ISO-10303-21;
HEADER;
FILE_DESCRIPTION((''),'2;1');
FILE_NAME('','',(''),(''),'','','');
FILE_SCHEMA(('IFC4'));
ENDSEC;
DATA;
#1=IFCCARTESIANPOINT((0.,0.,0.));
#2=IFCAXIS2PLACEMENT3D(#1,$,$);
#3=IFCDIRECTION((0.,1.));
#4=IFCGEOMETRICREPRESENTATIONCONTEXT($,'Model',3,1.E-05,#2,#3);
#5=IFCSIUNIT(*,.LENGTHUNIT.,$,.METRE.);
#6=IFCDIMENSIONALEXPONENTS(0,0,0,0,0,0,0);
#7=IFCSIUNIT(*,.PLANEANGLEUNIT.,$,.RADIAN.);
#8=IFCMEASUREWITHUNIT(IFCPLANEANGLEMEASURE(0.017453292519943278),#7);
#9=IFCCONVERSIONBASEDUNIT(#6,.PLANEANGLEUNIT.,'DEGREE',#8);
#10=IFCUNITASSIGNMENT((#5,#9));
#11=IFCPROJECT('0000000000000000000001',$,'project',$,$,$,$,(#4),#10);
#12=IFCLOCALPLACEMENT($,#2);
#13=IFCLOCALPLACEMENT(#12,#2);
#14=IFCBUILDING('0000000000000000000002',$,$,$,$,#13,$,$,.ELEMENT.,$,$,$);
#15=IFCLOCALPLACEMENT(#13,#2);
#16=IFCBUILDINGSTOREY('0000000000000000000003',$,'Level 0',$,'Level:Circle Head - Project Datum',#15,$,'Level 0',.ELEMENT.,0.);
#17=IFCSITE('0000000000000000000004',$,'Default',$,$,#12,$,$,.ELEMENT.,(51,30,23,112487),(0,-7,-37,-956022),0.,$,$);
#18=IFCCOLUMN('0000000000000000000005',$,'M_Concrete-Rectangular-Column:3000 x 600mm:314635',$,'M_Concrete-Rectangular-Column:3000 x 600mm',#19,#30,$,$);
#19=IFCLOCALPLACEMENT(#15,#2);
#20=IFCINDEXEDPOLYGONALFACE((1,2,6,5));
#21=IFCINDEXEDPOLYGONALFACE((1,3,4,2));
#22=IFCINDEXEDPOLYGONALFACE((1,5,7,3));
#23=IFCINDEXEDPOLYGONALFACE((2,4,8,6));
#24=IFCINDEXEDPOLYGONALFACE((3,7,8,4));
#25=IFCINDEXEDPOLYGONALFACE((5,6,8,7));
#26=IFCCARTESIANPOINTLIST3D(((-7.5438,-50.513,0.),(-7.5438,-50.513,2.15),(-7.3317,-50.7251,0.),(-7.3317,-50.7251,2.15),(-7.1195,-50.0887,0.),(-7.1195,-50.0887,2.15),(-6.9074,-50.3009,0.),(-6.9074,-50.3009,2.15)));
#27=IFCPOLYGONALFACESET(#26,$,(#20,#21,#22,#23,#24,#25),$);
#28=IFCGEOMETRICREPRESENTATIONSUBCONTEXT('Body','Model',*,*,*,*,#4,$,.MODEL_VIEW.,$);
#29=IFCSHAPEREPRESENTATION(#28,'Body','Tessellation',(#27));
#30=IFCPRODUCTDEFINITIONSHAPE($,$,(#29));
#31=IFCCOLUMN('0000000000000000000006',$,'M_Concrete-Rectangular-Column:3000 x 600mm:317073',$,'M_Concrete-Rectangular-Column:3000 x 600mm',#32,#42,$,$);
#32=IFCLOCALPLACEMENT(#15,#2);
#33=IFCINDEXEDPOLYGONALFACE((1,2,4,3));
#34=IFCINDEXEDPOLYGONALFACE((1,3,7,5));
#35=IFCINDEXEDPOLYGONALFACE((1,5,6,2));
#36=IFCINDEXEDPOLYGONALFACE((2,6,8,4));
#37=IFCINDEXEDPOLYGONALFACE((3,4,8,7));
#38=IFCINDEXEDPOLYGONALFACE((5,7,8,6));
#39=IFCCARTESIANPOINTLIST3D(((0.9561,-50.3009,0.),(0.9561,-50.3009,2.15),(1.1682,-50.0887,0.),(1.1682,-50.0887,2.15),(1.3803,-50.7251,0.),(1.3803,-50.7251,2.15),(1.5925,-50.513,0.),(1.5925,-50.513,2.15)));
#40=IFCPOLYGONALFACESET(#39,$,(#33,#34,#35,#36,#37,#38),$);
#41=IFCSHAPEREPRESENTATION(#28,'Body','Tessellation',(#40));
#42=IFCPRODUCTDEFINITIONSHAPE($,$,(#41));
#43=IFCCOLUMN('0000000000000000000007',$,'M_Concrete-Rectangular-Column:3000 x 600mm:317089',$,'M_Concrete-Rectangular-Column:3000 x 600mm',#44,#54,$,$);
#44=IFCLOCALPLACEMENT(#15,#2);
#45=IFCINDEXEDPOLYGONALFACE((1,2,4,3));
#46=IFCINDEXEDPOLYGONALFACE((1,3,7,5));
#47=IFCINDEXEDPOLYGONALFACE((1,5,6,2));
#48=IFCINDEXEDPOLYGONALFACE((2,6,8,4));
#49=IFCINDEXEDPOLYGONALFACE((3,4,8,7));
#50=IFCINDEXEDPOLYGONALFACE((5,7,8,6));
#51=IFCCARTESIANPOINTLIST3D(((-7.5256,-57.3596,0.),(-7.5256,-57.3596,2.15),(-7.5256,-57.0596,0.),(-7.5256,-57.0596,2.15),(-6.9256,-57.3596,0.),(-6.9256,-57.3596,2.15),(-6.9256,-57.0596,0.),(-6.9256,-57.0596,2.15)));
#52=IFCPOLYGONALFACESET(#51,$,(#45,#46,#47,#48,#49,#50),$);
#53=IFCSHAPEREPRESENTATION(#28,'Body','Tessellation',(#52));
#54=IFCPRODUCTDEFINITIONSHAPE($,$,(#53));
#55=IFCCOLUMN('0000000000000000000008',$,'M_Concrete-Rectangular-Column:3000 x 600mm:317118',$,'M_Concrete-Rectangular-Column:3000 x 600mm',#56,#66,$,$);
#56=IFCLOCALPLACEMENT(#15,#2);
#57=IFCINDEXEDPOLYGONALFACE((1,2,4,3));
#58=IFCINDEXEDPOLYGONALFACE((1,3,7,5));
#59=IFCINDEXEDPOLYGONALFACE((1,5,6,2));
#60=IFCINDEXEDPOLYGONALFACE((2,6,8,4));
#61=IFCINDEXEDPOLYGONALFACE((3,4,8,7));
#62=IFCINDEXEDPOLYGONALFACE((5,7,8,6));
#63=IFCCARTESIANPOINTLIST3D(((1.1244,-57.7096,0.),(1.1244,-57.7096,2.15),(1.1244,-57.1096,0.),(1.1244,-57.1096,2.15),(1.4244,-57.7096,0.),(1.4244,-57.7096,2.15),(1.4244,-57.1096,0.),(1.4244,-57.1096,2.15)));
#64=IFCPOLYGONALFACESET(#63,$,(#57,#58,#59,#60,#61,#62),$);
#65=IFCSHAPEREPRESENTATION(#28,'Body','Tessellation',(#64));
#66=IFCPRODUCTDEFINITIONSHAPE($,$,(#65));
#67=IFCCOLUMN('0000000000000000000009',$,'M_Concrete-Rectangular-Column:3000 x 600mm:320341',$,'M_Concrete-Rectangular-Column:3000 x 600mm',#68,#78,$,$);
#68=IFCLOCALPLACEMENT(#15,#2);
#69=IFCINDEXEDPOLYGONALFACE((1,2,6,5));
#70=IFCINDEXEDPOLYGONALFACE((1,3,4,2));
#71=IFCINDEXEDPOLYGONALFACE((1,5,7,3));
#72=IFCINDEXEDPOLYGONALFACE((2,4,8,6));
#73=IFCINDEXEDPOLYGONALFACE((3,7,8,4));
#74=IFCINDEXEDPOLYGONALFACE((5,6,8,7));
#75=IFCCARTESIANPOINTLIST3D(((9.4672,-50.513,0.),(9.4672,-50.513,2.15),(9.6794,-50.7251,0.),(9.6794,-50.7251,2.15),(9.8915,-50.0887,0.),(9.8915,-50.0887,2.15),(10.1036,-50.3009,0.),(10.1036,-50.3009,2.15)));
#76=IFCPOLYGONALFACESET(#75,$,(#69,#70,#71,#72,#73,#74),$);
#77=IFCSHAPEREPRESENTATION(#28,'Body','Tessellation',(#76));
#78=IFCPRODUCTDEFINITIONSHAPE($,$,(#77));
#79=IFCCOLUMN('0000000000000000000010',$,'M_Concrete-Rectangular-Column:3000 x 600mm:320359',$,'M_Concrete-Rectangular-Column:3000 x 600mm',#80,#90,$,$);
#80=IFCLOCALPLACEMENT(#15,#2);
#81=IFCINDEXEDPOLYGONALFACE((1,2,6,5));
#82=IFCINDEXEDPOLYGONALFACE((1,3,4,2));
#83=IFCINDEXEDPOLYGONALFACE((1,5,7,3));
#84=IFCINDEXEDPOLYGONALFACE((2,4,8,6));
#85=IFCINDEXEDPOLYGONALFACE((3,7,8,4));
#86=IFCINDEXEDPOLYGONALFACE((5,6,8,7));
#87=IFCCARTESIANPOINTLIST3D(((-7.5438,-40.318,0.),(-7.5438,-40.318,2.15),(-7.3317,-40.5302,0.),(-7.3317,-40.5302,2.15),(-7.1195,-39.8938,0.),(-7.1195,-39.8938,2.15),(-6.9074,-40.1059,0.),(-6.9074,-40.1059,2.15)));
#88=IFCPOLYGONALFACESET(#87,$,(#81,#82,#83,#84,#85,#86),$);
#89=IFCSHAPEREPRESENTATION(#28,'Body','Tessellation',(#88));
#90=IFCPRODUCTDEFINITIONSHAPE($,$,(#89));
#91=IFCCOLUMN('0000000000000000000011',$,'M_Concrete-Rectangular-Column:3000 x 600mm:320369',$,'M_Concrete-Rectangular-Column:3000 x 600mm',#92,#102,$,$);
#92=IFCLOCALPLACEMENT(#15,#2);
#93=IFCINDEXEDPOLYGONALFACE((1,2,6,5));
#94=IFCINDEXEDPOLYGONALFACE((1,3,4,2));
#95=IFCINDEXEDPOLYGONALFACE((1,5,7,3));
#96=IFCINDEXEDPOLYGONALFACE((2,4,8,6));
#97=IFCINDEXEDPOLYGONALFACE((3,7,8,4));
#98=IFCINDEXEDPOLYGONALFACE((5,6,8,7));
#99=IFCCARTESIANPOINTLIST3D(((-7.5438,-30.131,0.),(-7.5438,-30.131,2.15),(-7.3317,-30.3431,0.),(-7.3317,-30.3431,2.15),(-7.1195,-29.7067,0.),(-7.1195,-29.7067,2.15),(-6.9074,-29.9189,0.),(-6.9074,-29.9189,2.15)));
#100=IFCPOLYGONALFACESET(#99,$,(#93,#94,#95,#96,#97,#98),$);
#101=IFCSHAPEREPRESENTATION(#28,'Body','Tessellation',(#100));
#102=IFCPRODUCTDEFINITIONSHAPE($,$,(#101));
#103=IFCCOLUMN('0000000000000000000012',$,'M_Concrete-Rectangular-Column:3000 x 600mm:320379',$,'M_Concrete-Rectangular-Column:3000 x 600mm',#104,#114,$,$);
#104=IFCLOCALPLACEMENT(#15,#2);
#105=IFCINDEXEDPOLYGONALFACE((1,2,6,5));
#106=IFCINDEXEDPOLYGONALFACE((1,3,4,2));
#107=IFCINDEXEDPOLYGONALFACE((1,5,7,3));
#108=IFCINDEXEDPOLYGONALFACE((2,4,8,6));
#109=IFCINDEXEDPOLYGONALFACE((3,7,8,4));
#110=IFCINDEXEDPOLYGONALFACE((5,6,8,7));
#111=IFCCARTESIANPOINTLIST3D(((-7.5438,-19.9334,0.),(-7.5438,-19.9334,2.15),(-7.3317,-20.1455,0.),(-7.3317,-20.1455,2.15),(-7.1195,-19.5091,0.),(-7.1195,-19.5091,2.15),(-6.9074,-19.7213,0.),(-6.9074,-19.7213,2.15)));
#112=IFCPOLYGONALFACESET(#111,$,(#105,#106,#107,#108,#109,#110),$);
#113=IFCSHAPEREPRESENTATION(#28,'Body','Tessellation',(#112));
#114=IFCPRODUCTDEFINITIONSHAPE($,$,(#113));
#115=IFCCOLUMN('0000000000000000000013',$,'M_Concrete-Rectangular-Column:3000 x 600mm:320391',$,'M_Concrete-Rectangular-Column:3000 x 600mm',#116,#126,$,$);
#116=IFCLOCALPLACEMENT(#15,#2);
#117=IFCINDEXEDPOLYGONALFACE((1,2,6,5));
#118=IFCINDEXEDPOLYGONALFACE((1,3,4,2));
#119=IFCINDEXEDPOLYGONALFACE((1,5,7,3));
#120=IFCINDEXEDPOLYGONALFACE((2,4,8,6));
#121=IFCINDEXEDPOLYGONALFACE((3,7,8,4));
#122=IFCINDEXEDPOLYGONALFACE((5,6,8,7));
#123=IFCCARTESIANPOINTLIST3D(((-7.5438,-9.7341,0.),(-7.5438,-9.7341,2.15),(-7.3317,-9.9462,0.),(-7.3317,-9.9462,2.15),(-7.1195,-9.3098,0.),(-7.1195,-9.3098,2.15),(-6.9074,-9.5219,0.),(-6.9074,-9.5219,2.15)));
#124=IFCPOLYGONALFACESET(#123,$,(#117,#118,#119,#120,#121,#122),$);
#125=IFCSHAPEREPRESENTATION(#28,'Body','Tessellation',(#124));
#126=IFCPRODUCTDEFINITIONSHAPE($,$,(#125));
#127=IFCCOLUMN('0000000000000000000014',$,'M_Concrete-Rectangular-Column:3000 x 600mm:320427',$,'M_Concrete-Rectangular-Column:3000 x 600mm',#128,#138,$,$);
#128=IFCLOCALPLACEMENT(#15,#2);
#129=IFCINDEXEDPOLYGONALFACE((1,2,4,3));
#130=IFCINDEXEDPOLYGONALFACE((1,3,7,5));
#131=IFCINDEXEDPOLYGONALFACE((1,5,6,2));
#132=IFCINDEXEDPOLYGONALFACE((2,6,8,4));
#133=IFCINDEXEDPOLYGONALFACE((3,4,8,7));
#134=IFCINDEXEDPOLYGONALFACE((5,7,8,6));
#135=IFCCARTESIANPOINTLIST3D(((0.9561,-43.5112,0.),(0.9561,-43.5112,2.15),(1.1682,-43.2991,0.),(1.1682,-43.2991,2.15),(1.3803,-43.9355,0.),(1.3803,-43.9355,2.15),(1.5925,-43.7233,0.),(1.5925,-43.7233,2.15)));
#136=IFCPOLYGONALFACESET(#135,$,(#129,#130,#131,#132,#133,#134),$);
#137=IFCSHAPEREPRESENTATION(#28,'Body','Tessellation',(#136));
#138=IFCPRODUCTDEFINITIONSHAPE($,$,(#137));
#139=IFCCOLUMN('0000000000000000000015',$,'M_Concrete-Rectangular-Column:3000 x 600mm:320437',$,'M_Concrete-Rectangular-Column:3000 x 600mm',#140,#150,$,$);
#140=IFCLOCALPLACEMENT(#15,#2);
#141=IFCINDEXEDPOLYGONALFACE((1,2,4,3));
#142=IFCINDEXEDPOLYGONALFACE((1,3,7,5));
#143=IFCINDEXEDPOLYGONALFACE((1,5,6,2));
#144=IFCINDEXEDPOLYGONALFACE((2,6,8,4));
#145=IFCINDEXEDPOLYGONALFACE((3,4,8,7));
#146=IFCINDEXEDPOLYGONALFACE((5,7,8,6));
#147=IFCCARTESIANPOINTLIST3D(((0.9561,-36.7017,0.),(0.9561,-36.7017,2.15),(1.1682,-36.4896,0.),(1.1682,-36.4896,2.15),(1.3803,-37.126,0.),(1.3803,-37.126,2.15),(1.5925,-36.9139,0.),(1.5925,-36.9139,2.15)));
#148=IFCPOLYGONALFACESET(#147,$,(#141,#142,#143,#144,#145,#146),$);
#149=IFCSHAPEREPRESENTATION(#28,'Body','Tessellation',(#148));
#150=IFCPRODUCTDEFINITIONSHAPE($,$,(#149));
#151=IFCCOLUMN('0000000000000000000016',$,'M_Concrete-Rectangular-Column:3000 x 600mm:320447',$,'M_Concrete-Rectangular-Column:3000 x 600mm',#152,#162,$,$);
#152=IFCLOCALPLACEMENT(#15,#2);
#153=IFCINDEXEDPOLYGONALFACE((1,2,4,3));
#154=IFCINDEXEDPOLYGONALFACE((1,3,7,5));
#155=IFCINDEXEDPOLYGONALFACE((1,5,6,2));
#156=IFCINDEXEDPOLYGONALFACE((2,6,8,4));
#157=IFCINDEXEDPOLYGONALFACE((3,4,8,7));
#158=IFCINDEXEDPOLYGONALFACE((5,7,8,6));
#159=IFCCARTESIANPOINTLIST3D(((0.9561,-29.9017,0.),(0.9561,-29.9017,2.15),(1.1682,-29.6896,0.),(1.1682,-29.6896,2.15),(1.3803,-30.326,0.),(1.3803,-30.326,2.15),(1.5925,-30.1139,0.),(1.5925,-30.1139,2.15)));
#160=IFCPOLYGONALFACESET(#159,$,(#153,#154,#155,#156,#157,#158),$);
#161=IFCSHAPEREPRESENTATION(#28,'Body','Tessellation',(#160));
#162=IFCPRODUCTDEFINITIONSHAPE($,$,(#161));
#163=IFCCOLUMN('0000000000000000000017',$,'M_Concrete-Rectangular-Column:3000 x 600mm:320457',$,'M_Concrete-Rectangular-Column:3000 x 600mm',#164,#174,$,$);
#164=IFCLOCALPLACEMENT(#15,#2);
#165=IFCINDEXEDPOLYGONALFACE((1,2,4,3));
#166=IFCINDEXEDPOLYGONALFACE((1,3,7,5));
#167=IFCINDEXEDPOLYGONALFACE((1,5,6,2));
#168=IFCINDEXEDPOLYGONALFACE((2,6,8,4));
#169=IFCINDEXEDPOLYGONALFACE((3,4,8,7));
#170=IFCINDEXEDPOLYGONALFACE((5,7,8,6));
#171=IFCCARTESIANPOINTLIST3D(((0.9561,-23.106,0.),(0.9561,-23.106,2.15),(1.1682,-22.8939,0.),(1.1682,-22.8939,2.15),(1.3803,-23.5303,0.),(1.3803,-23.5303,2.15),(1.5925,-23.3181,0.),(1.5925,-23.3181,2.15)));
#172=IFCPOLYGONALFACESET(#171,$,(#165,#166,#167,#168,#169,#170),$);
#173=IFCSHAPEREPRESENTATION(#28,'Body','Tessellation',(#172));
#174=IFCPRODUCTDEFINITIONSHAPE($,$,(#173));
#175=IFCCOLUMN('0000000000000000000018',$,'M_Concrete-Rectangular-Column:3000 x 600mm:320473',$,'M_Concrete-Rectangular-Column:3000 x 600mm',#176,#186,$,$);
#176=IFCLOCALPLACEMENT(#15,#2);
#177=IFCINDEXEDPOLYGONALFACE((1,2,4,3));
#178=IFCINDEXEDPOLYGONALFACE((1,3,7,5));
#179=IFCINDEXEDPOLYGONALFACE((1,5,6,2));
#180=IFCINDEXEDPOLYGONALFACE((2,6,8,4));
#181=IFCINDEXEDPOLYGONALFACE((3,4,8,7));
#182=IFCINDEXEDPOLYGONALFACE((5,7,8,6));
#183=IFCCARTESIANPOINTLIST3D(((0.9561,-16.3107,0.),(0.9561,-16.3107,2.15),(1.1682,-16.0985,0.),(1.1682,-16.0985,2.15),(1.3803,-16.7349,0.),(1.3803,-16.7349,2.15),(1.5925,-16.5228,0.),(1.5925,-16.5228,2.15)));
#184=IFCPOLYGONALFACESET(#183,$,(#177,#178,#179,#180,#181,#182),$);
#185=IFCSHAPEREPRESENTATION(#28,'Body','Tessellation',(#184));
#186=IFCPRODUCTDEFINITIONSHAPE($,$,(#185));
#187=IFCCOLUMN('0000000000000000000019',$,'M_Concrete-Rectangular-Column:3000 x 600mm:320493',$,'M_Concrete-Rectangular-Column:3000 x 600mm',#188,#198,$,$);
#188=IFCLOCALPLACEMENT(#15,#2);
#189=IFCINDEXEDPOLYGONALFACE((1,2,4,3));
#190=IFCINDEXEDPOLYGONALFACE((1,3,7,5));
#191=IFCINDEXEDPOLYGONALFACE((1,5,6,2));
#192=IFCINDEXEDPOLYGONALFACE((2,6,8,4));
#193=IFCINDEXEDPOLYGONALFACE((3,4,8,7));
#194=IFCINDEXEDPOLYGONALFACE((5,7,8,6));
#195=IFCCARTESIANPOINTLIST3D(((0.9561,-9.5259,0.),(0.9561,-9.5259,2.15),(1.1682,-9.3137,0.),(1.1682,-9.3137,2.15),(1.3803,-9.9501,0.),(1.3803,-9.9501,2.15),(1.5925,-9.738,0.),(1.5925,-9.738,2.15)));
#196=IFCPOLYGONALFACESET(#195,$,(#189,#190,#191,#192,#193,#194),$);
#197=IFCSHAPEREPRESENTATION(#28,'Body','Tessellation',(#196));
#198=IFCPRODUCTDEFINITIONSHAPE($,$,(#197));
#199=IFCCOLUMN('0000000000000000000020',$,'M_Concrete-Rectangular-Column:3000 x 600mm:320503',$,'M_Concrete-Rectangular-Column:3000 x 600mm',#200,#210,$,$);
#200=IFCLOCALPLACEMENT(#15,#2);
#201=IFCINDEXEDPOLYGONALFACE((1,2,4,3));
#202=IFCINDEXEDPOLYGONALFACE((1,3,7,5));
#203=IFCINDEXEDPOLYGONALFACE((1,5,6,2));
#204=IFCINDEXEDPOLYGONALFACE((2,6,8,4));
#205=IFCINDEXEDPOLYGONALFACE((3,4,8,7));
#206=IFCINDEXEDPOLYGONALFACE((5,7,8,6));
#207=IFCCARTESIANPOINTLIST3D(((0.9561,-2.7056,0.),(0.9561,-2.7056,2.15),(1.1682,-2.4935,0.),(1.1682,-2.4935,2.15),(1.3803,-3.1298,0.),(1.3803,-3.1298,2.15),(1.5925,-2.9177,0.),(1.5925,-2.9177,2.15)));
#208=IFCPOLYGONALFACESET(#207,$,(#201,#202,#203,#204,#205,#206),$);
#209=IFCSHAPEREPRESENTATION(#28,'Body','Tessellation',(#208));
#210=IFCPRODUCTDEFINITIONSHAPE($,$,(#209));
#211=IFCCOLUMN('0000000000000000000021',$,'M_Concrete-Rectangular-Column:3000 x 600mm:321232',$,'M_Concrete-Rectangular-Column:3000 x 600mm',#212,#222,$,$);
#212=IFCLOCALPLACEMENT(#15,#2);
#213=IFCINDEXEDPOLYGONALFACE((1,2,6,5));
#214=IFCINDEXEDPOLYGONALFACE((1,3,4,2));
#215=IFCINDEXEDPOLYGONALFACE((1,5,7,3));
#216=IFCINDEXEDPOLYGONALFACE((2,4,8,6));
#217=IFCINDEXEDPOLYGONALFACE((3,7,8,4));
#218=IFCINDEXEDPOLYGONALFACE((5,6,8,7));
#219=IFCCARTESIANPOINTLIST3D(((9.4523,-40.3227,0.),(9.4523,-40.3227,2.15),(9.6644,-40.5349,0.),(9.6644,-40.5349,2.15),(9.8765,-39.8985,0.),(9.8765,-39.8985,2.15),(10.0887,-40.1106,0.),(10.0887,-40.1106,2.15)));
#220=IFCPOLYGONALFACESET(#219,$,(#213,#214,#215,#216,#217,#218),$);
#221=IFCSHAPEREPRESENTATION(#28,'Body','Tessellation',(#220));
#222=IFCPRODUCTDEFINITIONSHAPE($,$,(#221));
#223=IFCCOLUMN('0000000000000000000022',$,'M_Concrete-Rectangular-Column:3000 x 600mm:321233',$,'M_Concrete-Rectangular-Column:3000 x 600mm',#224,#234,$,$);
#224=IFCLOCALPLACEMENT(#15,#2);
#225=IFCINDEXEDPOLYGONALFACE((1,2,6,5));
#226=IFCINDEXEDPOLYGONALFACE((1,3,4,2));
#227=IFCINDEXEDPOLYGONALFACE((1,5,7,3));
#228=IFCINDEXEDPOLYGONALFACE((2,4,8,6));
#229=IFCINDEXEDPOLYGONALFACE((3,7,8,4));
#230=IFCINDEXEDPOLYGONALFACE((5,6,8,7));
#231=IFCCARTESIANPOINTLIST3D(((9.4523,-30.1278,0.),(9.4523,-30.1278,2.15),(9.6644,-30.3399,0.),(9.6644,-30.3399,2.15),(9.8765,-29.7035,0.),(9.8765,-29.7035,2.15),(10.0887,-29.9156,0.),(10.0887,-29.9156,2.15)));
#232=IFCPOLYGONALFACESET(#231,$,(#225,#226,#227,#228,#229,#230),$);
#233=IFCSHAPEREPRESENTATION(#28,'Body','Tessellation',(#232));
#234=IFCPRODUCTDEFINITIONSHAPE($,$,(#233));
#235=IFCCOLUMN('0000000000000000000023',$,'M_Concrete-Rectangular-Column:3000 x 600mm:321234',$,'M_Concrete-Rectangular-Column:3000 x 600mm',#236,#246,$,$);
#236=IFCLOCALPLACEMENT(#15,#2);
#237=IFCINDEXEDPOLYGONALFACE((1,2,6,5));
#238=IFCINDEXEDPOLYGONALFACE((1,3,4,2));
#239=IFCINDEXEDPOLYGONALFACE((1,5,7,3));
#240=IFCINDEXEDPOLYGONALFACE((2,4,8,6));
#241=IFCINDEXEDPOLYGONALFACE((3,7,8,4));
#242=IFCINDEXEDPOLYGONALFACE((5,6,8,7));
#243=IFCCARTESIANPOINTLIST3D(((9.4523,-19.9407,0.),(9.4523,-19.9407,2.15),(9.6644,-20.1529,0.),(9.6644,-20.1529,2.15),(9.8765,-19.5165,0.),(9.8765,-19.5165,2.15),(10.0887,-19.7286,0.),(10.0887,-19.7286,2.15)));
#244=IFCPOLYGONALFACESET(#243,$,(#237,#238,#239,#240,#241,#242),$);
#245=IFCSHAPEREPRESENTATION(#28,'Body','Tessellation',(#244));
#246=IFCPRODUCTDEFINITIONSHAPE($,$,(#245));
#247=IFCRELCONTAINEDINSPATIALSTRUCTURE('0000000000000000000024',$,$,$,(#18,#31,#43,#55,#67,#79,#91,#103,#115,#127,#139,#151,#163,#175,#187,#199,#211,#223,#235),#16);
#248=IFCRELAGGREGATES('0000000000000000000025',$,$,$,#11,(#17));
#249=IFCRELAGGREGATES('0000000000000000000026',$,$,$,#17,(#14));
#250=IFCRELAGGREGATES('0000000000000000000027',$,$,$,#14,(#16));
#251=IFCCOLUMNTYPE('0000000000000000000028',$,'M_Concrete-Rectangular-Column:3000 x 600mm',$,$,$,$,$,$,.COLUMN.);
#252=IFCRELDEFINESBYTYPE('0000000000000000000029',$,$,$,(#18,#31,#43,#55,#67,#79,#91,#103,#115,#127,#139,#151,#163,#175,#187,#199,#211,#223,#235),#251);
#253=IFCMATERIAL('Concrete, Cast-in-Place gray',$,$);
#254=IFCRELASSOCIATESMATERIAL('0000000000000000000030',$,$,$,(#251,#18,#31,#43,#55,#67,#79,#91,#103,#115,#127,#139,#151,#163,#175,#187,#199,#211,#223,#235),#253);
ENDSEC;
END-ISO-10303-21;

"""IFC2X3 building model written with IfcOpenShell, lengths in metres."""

from ifc_helpers import new_model, entity, si_unit, converted_unit, direction, frame, origin, origin_2d_with_axis, place, context, subcontext, project, spatial, rectangle, extrude, source, transform, mapped, material, type_object, type_shapes, element, save


model = new_model("IFC2X3")

# Units and contexts
model_context = context("Model", 3, precision=1e-05, world=origin(), true_north=direction((0.0, 1.0)))
body_context = subcontext(model_context, "Body", "Model", "MODEL_VIEW")
ifc_project = project(units=[si_unit("LENGTHUNIT", "METRE"), converted_unit("PLANEANGLEUNIT", "DEGREE", entity("IfcPlaneAngleMeasure", 0.017453292519943278), si_unit("PLANEANGLEUNIT", "RADIAN"), dimensions=[0, 0, 0, 0, 0, 0, 0])], contexts=[model_context])

# Site, building, storey
site_placement = place(None, origin())
site = spatial("IfcSite", under=ifc_project, at=site_placement, Name="Default", CompositionType="ELEMENT", RefLatitude=(51, 30, 23, 112487), RefLongitude=(0, -7, -37, -956022), RefElevation=0.0)
building_placement = place(site_placement, origin())
building = spatial("IfcBuilding", under=site, at=building_placement, CompositionType="ELEMENT")
storey_placement = place(building_placement, origin())
storey = spatial("IfcBuildingStorey", under=building, at=storey_placement, Name="Level 0", ObjectType="Level:Circle Head - Project Datum", LongName="Level 0", CompositionType="ELEMENT", Elevation=0.0)

# Columns
ifc_material_1 = material(Name="Concrete, Cast-in-Place gray")
column_type = type_object("IfcColumnType", Name="M_Concrete-Rectangular-Column:3000 x 600mm", PredefinedType="COLUMN", material=ifc_material_1)
shared_shape_1 = source(origin(), body_context, "Body", "SweptSolid", [
    extrude(rectangle(XDim=0.3, YDim=0.6, at=origin_2d_with_axis()), frame((0.0, 0.0, 0.0), z_axis=(0.0, 0.0, 1.0), x_axis=(-1.0, 0.0, 0.0)), (0.0, 0.0, 1.0), 2.15),
])
type_shapes(column_type, [shared_shape_1])
for number, where, z_axis, x_axis, name in (
    (1, (-7.2256, -50.4069, 0.0), (0.0, 0.0, 1.0), (0.707107, -0.707107, 0.0), "M_Concrete-Rectangular-Column:3000 x 600mm:314635"),
    (2, (1.2743, -50.4069, 0.0), (0.0, 0.0, 1.0), (0.707107, 0.707107, 0.0), "M_Concrete-Rectangular-Column:3000 x 600mm:317073"),
    (3, (-7.2256, -57.2096, 0.0), (0.0, 0.0, 1.0), (0.0, -1.0, 0.0), "M_Concrete-Rectangular-Column:3000 x 600mm:317089"),
):
    element("IfcColumn", number, at=place(storey_placement, frame(where, z_axis=z_axis, x_axis=x_axis)), inside=storey, type_object=column_type, material=ifc_material_1, Name=name, ObjectType="M_Concrete-Rectangular-Column:3000 x 600mm", context=body_context, shape_type="MappedRepresentation", body=[
        mapped(shared_shape_1, transform((0.0, 0.0, 0.0), scale=1.0)),
    ])
column_placement = place(storey_placement, frame((1.2744, -57.4096, 0.0)))
element("IfcColumn", 4, at=column_placement, inside=storey, type_object=column_type, material=ifc_material_1, Name="M_Concrete-Rectangular-Column:3000 x 600mm:317118", ObjectType="M_Concrete-Rectangular-Column:3000 x 600mm", context=body_context, shape_type="MappedRepresentation", body=[
    mapped(shared_shape_1, transform((0.0, 0.0, 0.0), scale=1.0)),
])
for number, where, z_axis, x_axis, name in (
    (5, (9.7854, -50.4069, 0.0), (0.0, 0.0, 1.0), (0.707107, -0.707107, 0.0), "M_Concrete-Rectangular-Column:3000 x 600mm:320341"),
    (6, (-7.2256, -40.212, 0.0), (0.0, 0.0, 1.0), (0.707107, -0.707107, 0.0), "M_Concrete-Rectangular-Column:3000 x 600mm:320359"),
    (7, (-7.2256, -30.0249, 0.0), (0.0, 0.0, 1.0), (0.707107, -0.707107, 0.0), "M_Concrete-Rectangular-Column:3000 x 600mm:320369"),
    (8, (-7.2256, -19.8273, 0.0), (0.0, 0.0, 1.0), (0.707107, -0.707107, 0.0), "M_Concrete-Rectangular-Column:3000 x 600mm:320379"),
    (9, (-7.2256, -9.628, 0.0), (0.0, 0.0, 1.0), (0.707107, -0.707107, 0.0), "M_Concrete-Rectangular-Column:3000 x 600mm:320391"),
    (10, (1.2743, -43.6173, 0.0), (0.0, 0.0, 1.0), (0.707107, 0.707107, 0.0), "M_Concrete-Rectangular-Column:3000 x 600mm:320427"),
    (11, (1.2743, -36.8078, 0.0), (0.0, 0.0, 1.0), (0.707107, 0.707107, 0.0), "M_Concrete-Rectangular-Column:3000 x 600mm:320437"),
    (12, (1.2743, -30.0078, 0.0), (0.0, 0.0, 1.0), (0.707107, 0.707107, 0.0), "M_Concrete-Rectangular-Column:3000 x 600mm:320447"),
    (13, (1.2743, -23.2121, 0.0), (0.0, 0.0, 1.0), (0.707107, 0.707107, 0.0), "M_Concrete-Rectangular-Column:3000 x 600mm:320457"),
    (14, (1.2743, -16.4167, 0.0), (0.0, 0.0, 1.0), (0.707107, 0.707107, 0.0), "M_Concrete-Rectangular-Column:3000 x 600mm:320473"),
    (15, (1.2743, -9.6319, 0.0), (0.0, 0.0, 1.0), (0.707107, 0.707107, 0.0), "M_Concrete-Rectangular-Column:3000 x 600mm:320493"),
    (16, (1.2743, -2.8117, 0.0), (0.0, 0.0, 1.0), (0.707107, 0.707107, 0.0), "M_Concrete-Rectangular-Column:3000 x 600mm:320503"),
    (17, (9.7705, -40.2167, 0.0), (0.0, 0.0, 1.0), (0.707107, -0.707107, 0.0), "M_Concrete-Rectangular-Column:3000 x 600mm:321232"),
    (18, (9.7705, -30.0217, 0.0), (0.0, 0.0, 1.0), (0.707107, -0.707107, 0.0), "M_Concrete-Rectangular-Column:3000 x 600mm:321233"),
    (19, (9.7705, -19.8347, 0.0), (0.0, 0.0, 1.0), (0.707107, -0.707107, 0.0), "M_Concrete-Rectangular-Column:3000 x 600mm:321234"),
):
    element("IfcColumn", number, at=place(storey_placement, frame(where, z_axis=z_axis, x_axis=x_axis)), inside=storey, type_object=column_type, material=ifc_material_1, Name=name, ObjectType="M_Concrete-Rectangular-Column:3000 x 600mm", context=body_context, shape_type="MappedRepresentation", body=[
        mapped(shared_shape_1, transform((0.0, 0.0, 0.0), scale=1.0)),
    ])

save(model, "model.ifc")
